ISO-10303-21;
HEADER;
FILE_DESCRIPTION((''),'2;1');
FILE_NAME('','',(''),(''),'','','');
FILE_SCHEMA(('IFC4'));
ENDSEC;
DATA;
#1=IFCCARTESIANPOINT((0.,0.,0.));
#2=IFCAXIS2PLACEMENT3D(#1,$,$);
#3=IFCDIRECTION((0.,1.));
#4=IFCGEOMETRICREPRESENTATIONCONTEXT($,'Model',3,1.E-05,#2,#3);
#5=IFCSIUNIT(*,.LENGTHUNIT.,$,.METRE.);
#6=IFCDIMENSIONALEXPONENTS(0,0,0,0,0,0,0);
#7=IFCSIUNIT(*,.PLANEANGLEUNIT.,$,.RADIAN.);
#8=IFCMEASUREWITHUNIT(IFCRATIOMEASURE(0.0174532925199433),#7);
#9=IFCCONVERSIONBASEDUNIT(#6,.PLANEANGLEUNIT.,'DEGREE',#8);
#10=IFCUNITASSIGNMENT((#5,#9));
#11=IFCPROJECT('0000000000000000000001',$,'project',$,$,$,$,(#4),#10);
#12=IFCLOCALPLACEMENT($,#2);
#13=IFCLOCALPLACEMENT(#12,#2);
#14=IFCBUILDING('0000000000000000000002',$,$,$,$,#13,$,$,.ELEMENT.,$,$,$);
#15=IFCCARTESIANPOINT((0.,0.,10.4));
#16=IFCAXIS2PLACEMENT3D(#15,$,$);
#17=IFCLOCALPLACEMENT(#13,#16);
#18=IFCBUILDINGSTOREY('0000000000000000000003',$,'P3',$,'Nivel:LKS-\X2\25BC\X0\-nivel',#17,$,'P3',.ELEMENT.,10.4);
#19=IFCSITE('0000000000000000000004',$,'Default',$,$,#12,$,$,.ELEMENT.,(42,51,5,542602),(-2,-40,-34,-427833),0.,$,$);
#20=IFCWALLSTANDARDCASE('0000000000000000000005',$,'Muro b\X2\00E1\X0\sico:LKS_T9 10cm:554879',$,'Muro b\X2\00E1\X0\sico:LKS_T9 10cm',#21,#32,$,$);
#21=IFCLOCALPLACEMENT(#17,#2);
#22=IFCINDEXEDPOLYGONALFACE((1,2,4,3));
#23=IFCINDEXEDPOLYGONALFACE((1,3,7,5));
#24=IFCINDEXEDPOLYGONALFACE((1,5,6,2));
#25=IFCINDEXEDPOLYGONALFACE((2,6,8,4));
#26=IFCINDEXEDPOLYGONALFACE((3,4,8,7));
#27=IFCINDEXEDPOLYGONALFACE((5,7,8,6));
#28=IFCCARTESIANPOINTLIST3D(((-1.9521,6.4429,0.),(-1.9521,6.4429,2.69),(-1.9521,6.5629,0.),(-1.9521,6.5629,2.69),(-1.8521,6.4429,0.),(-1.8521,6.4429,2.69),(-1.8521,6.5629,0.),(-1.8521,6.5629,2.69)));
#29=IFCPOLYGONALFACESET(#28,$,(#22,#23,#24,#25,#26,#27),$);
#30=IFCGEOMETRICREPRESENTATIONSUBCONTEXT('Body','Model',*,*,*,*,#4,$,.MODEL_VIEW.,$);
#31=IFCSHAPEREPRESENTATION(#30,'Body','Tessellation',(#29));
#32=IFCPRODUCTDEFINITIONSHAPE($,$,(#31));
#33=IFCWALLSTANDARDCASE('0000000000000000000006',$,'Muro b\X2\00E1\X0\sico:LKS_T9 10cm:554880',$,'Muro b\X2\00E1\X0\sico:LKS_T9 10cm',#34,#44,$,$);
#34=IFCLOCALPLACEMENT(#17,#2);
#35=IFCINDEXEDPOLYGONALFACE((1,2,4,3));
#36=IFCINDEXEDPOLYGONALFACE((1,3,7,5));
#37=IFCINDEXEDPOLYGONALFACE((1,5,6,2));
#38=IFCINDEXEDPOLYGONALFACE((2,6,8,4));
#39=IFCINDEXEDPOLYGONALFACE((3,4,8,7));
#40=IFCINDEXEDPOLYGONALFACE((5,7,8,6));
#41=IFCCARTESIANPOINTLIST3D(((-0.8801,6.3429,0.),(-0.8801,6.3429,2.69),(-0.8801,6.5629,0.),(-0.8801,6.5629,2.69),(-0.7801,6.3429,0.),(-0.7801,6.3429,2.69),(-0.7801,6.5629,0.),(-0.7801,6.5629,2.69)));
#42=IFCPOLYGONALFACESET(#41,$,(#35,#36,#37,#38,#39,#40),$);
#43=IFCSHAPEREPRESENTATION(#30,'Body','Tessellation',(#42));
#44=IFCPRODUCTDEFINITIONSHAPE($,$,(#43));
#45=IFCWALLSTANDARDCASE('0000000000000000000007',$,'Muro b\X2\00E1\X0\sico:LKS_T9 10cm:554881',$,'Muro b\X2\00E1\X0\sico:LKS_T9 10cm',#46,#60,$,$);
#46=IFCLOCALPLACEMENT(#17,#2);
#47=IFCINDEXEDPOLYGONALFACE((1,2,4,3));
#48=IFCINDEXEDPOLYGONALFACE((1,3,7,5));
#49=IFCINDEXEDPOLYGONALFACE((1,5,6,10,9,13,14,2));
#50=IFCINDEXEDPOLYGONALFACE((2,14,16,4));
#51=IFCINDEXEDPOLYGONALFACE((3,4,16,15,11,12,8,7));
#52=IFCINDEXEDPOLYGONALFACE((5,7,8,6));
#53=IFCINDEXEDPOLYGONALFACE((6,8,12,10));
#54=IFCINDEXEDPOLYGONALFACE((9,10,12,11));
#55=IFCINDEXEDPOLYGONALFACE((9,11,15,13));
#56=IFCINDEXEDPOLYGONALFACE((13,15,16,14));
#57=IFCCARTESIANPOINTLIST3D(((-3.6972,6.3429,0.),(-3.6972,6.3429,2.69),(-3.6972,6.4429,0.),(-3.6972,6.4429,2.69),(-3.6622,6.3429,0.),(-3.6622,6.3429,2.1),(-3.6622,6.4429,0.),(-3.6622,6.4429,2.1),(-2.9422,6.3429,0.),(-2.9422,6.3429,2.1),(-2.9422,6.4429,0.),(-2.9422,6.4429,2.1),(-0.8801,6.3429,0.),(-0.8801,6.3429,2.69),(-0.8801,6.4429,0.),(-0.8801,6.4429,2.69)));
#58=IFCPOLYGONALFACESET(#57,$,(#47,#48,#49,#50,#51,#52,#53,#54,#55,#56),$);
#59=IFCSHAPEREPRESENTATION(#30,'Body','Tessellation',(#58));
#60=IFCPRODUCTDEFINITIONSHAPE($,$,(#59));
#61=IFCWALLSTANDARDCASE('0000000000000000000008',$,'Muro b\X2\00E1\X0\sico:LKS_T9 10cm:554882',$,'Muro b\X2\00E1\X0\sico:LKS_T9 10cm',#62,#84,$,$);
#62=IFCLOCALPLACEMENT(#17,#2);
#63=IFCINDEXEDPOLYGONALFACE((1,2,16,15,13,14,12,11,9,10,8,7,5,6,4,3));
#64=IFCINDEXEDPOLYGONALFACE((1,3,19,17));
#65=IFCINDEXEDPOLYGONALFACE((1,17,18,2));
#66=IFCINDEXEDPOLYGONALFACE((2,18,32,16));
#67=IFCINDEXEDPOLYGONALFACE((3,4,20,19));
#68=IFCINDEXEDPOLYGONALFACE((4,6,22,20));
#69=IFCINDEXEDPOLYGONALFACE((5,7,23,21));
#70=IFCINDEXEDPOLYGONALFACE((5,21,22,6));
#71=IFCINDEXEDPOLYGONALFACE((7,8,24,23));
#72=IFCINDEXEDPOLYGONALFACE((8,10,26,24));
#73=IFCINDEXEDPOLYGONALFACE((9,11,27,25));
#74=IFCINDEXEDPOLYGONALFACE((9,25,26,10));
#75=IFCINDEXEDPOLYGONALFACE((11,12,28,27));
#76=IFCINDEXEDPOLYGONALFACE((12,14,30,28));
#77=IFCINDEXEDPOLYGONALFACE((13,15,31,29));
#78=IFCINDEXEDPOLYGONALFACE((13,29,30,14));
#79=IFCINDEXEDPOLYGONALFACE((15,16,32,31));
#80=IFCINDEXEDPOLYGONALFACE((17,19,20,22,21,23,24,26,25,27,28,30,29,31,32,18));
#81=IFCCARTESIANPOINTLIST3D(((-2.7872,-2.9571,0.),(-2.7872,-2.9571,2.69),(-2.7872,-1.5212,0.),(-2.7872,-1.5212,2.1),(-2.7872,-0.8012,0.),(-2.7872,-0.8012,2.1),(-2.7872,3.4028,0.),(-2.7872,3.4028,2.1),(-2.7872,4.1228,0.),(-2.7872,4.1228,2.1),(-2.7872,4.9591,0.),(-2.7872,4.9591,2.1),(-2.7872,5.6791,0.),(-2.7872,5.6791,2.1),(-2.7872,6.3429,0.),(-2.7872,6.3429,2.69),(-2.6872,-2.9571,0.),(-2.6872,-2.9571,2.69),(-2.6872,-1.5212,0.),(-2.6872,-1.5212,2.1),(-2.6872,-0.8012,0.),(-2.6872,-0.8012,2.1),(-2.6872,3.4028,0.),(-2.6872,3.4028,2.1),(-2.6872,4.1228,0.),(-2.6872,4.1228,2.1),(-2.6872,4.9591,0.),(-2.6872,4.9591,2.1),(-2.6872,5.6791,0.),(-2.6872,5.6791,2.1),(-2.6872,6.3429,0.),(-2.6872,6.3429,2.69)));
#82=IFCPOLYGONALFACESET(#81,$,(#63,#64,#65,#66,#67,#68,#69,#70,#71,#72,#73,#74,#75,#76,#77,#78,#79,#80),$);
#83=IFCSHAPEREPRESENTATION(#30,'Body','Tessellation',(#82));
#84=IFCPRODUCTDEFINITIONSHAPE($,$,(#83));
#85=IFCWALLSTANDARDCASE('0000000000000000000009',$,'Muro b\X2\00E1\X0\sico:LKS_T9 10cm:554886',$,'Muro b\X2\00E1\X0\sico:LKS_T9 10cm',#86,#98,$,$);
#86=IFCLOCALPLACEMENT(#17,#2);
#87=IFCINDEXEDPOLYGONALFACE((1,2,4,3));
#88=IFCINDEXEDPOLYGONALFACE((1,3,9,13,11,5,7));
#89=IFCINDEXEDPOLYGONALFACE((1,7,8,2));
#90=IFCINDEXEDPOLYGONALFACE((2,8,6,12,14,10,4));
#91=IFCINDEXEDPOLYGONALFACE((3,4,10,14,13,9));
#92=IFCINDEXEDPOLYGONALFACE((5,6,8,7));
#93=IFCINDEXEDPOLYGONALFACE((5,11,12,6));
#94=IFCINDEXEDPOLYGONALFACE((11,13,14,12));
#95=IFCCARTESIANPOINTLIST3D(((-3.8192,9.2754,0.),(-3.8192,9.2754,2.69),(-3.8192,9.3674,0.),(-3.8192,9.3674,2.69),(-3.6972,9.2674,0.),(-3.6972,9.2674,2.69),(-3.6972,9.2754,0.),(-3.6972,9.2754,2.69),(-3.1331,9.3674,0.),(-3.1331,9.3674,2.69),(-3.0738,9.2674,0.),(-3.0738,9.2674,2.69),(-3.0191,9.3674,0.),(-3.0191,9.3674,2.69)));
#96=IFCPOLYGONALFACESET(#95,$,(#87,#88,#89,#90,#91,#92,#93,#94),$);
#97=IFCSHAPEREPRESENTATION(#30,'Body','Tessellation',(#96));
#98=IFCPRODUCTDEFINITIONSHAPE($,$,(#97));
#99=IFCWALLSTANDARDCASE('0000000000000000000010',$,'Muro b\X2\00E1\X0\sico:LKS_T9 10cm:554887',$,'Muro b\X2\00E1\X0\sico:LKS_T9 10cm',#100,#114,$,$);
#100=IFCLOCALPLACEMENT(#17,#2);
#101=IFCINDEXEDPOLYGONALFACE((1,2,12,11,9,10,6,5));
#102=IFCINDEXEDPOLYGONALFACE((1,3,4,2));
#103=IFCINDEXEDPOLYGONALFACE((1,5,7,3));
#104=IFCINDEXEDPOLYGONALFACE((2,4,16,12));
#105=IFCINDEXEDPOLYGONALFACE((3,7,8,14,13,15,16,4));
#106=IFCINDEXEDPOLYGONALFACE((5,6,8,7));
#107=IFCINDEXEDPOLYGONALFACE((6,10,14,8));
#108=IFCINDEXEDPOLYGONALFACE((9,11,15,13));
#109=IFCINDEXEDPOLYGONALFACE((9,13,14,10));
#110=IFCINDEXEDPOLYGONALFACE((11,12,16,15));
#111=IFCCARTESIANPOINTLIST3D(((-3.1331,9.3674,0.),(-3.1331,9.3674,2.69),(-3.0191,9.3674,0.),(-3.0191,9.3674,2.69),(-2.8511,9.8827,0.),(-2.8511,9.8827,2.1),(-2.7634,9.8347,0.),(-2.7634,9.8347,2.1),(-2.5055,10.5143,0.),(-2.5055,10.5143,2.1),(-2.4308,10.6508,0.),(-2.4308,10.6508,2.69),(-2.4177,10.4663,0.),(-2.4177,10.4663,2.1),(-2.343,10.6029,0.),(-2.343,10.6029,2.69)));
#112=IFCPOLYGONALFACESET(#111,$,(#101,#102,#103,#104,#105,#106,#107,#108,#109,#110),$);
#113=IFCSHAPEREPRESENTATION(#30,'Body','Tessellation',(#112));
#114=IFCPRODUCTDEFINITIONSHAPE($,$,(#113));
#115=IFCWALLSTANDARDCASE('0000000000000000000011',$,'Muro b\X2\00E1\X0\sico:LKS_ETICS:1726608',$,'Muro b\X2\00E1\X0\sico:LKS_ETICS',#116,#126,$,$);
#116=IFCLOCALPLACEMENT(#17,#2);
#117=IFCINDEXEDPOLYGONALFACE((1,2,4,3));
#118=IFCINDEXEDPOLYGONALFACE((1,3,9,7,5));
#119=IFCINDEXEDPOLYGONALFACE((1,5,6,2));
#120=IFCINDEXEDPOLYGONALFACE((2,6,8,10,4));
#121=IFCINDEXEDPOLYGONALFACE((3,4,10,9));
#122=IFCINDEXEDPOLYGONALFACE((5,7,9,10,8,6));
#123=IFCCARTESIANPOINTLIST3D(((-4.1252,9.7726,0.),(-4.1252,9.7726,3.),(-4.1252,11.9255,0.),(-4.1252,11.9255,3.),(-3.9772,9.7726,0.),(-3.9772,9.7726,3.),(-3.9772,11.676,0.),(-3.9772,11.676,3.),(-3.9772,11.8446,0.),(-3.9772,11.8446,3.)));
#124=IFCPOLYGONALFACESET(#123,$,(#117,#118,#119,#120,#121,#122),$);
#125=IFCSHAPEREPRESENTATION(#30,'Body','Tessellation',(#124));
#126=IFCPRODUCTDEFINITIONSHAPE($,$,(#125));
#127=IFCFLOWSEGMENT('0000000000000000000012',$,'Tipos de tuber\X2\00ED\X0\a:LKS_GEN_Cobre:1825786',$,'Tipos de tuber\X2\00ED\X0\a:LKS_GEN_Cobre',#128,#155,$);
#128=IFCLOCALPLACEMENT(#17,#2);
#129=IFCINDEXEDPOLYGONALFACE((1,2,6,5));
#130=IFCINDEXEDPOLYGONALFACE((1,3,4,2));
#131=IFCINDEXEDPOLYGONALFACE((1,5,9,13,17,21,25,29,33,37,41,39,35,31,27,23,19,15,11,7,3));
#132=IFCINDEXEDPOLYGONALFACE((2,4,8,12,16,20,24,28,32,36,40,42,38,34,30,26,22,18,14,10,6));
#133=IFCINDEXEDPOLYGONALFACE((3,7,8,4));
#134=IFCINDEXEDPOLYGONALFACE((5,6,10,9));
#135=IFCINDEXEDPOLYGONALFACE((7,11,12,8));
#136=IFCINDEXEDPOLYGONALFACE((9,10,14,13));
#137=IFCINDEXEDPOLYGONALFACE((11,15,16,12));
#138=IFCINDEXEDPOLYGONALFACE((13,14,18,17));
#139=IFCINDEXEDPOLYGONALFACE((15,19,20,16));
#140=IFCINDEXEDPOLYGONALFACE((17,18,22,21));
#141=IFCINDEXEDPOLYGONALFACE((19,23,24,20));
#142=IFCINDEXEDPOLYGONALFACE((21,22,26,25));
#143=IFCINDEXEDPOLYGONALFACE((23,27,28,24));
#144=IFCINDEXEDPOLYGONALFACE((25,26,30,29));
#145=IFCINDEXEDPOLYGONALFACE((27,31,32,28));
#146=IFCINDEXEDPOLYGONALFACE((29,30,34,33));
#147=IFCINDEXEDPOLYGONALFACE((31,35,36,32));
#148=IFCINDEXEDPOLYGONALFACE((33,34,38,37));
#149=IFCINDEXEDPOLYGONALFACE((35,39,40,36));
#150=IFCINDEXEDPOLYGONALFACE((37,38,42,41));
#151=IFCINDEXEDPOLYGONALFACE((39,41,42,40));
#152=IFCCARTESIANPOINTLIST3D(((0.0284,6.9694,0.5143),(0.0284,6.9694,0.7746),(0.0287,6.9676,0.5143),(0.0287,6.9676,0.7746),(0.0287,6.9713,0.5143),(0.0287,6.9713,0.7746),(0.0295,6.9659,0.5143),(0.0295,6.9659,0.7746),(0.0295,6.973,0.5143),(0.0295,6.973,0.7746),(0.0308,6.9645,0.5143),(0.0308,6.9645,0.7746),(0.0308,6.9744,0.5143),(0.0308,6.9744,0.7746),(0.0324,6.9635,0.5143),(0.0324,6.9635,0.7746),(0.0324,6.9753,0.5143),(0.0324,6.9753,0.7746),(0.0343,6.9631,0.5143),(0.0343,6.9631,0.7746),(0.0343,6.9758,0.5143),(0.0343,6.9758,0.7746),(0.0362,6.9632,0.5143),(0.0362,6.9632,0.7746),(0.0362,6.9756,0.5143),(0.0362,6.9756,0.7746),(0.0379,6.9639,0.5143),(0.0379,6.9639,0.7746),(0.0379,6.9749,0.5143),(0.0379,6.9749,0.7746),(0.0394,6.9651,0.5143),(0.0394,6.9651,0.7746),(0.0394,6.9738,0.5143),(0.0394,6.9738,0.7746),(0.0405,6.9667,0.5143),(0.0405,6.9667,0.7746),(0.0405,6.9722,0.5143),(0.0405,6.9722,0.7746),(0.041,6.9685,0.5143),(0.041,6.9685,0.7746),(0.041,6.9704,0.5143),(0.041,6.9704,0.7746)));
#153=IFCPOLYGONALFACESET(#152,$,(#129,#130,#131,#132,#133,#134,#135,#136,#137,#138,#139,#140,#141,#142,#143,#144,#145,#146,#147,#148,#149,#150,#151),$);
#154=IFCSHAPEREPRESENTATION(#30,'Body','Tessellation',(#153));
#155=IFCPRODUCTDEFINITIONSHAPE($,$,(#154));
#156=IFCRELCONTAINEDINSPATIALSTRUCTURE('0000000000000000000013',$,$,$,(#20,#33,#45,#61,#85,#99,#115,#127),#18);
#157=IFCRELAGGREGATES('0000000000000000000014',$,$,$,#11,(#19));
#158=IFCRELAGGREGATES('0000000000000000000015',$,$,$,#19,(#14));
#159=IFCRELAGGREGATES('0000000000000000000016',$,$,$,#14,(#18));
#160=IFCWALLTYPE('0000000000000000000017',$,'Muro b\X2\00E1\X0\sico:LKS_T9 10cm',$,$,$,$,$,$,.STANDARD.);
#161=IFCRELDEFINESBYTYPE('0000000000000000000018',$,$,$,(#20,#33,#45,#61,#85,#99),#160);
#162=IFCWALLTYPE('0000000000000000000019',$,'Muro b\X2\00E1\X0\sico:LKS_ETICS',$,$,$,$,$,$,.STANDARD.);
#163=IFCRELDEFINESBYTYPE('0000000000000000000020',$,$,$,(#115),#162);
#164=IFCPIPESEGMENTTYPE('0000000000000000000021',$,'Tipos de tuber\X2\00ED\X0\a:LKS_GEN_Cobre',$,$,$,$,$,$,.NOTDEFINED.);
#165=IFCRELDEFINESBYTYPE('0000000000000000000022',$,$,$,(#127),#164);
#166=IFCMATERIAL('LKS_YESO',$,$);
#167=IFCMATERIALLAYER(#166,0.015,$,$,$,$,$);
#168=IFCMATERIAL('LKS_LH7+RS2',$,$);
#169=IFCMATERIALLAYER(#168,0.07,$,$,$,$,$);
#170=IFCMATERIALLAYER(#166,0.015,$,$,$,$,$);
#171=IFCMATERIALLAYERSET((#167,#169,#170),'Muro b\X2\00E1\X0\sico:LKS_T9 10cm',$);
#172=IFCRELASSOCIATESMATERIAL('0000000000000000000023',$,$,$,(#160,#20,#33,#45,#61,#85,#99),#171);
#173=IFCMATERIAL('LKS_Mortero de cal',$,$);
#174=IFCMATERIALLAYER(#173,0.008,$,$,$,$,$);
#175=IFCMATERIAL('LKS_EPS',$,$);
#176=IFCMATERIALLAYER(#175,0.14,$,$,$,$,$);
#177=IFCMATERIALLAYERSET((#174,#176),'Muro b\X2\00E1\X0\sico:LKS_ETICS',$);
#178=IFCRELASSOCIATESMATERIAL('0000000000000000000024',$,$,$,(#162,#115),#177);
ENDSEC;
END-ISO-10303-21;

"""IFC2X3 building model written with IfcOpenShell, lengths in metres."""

from ifc_helpers import new_model, entity, si_unit, converted_unit, direction, frame, frame_2d, origin, place, context, subcontext, project, spatial, polyline, rectangle, circle, outline, extrude, material, layer, layer_set, layer_usage, type_object, element, save


model = new_model("IFC2X3")

# Units and contexts
model_context = context("Model", 3, precision=1e-05, world=origin(), true_north=direction((0.0, 1.0)))
body_context = subcontext(model_context, "Body", "Model", "MODEL_VIEW")
ifc_project = project(units=[si_unit("LENGTHUNIT", "METRE"), converted_unit("PLANEANGLEUNIT", "DEGREE", entity("IfcRatioMeasure", 0.0174532925199433), si_unit("PLANEANGLEUNIT", "RADIAN"), dimensions=[0, 0, 0, 0, 0, 0, 0])], contexts=[model_context])

# Site, building, storey
site_placement = place(None, origin())
site = spatial("IfcSite", under=ifc_project, at=site_placement, Name="Default", CompositionType="ELEMENT", RefLatitude=(42, 51, 5, 542602), RefLongitude=(-2, -40, -34, -427833), RefElevation=0.0)
building_placement = place(site_placement, origin())
building = spatial("IfcBuilding", under=site, at=building_placement, CompositionType="ELEMENT")
storey_placement = place(building_placement, frame((0.0, 0.0, 10.4)))
storey = spatial("IfcBuildingStorey", under=building, at=storey_placement, Name="P3", ObjectType="Nivel:LKS-▼-nivel", LongName="P3", CompositionType="ELEMENT", Elevation=10.4)

# Walls
ifc_material_1 = material(Name="LKS_YESO")
ifc_layer_1 = layer(ifc_material_1, 0.015)
ifc_material_2 = material(Name="LKS_LH7+RS2")
ifc_layer_2 = layer(ifc_material_2, 0.07)
ifc_layer_3 = layer(ifc_material_1, 0.015)
ifc_layer_set_1 = layer_set([ifc_layer_1, ifc_layer_2, ifc_layer_3], Name="Muro básico:LKS_T9 10cm")
ifc_layer_usage_1 = layer_usage(ifc_layer_set_1, "AXIS2", "NEGATIVE", 0.05)
wall_type_1 = type_object("IfcWallType", Name="Muro básico:LKS_T9 10cm", PredefinedType="STANDARD", material=ifc_layer_set_1)
wall_1_placement = place(storey_placement, frame((-1.9021, 6.5629, 0.0), z_axis=(0.0, 0.0, 1.0), x_axis=(0.0, -1.0, 0.0)))
element("IfcWallStandardCase", 1, at=wall_1_placement, inside=storey, type_object=wall_type_1, material=ifc_layer_usage_1, Name="Muro básico:LKS_T9 10cm:554879", ObjectType="Muro básico:LKS_T9 10cm", context=body_context, shape_type="SweptSolid", body=[
    extrude(rectangle(XDim=0.12, YDim=0.1, at=frame_2d((0.06, 0.0), x_axis=(-1.0, 0.0))), origin(), (0.0, 0.0, 1.0), 2.69),
])
ifc_layer_usage_2 = layer_usage(ifc_layer_set_1, "AXIS2", "NEGATIVE", 0.05)
wall_2_placement = place(storey_placement, frame((-0.8301, 6.5629, 0.0), z_axis=(0.0, 0.0, 1.0), x_axis=(0.0, -1.0, 0.0)))
element("IfcWallStandardCase", 2, at=wall_2_placement, inside=storey, type_object=wall_type_1, material=ifc_layer_usage_2, Name="Muro básico:LKS_T9 10cm:554880", ObjectType="Muro básico:LKS_T9 10cm", context=body_context, shape_type="SweptSolid", body=[
    extrude(rectangle(XDim=0.22, YDim=0.1, at=frame_2d((0.11, 0.0), x_axis=(-1.0, 0.0))), origin(), (0.0, 0.0, 1.0), 2.69),
])

# Wall, opening
ifc_layer_usage_3 = layer_usage(ifc_layer_set_1, "AXIS2", "NEGATIVE", 0.05)
wall_3_placement = place(storey_placement, frame((-0.8801, 6.3929, 0.0), z_axis=(0.0, 0.0, 1.0), x_axis=(-1.0, 0.0, 0.0)))
wall_3 = element("IfcWallStandardCase", 3, at=wall_3_placement, inside=storey, type_object=wall_type_1, material=ifc_layer_usage_3, Name="Muro básico:LKS_T9 10cm:554881", ObjectType="Muro básico:LKS_T9 10cm", context=body_context, shape_type="SweptSolid", body=[
    extrude(rectangle(XDim=2.8171, YDim=0.1, at=frame_2d((1.4085, 0.0), x_axis=(-1.0, 0.0))), origin(), (0.0, 0.0, 1.0), 2.69),
])
opening_1_placement = place(wall_3_placement, frame((2.7821, 0.05, 0.0)))
element("IfcOpeningElement", 4, at=opening_1_placement, cuts=wall_3, ObjectType="Opening", context=body_context, shape_type="SweptSolid", body=[
    extrude(rectangle(XDim=2.1, YDim=0.72, at=frame_2d((1.05, 0.36), x_axis=(1.0, 0.0))), frame((0.0, 0.0, 0.0), z_axis=(0.0, -1.0, 0.0), x_axis=(0.0, 0.0, 1.0)), (0.0, 0.0, 1.0), 0.1),
])

# Wall, openings
ifc_layer_usage_4 = layer_usage(ifc_layer_set_1, "AXIS2", "NEGATIVE", 0.05)
wall_4_placement = place(storey_placement, frame((-2.7372, 6.3429, 0.0), z_axis=(0.0, 0.0, 1.0), x_axis=(0.0, -1.0, 0.0)))
wall_4 = element("IfcWallStandardCase", 5, at=wall_4_placement, inside=storey, type_object=wall_type_1, material=ifc_layer_usage_4, Name="Muro básico:LKS_T9 10cm:554882", ObjectType="Muro básico:LKS_T9 10cm", context=body_context, shape_type="SweptSolid", body=[
    extrude(rectangle(XDim=9.3, YDim=0.1, at=frame_2d((4.65, 0.0), x_axis=(-1.0, 0.0))), origin(), (0.0, 0.0, 1.0), 2.69),
])
opening_2_placement = place(wall_4_placement, frame((0.6638, -0.05, 0.0)))
element("IfcOpeningElement", 6, at=opening_2_placement, cuts=wall_4, ObjectType="Opening", context=body_context, shape_type="SweptSolid", body=[
    extrude(rectangle(XDim=2.1, YDim=0.72, at=frame_2d((1.05, 0.36), x_axis=(1.0, 0.0))), frame((0.0, 0.0, 0.0), z_axis=(0.0, 1.0, 0.0), x_axis=(0.0, 0.0, 1.0)), (0.0, 0.0, 1.0), 0.1),
])
opening_3_placement = place(wall_4_placement, frame((2.22, -0.05, 0.0)))
element("IfcOpeningElement", 7, at=opening_3_placement, cuts=wall_4, ObjectType="Opening", context=body_context, shape_type="SweptSolid", body=[
    extrude(rectangle(XDim=2.1, YDim=0.72, at=frame_2d((1.05, 0.36), x_axis=(1.0, 0.0))), frame((0.0, 0.0, 0.0), z_axis=(0.0, 1.0, 0.0), x_axis=(0.0, 0.0, 1.0)), (0.0, 0.0, 1.0), 0.1),
])
opening_4_placement = place(wall_4_placement, frame((7.1441, -0.05, 0.0)))
element("IfcOpeningElement", 8, at=opening_4_placement, cuts=wall_4, ObjectType="Opening", context=body_context, shape_type="SweptSolid", body=[
    extrude(rectangle(XDim=2.1, YDim=0.72, at=frame_2d((1.05, 0.36), x_axis=(1.0, 0.0))), frame((0.0, 0.0, 0.0), z_axis=(0.0, 1.0, 0.0), x_axis=(0.0, 0.0, 1.0)), (0.0, 0.0, 1.0), 0.1),
])

# Wall
ifc_layer_usage_5 = layer_usage(ifc_layer_set_1, "AXIS2", "NEGATIVE", 0.05)
wall_5_placement = place(storey_placement, frame((-3.8192, 9.3174, 0.0)))
element("IfcWallStandardCase", 9, at=wall_5_placement, inside=storey, type_object=wall_type_1, material=ifc_layer_usage_5, Name="Muro básico:LKS_T9 10cm:554886", ObjectType="Muro básico:LKS_T9 10cm", context=body_context, shape_type="SweptSolid", body=[
    extrude(outline(polyline([(0.7454, -0.05), (0.8001, 0.05), (0.6861, 0.05), (0.0, 0.05), (0.0, -0.042), (0.122, -0.042), (0.122, -0.05), (0.7454, -0.05)])), origin(), (0.0, 0.0, 1.0), 2.69),
])

# Wall, opening
ifc_layer_usage_6 = layer_usage(ifc_layer_set_1, "AXIS2", "NEGATIVE", 0.05)
wall_6_placement = place(storey_placement, frame((-3.0892, 9.3434, 0.0), z_axis=(0.0, 0.0, 1.0), x_axis=(0.480022, 0.877256, 0.0)))
wall_6 = element("IfcWallStandardCase", 10, at=wall_6_placement, inside=storey, type_object=wall_type_1, material=ifc_layer_usage_6, Name="Muro básico:LKS_T9 10cm:554887", ObjectType="Muro básico:LKS_T9 10cm", context=body_context, shape_type="SweptSolid", body=[
    extrude(outline(polyline([(0.0547, -0.05), (1.4631, -0.05), (1.463, 0.05), (0.0, 0.05), (0.0547, -0.05)])), origin(), (0.0, 0.0, 1.0), 2.69),
])
opening_5_placement = place(wall_6_placement, frame((1.3075, 0.05, 0.0)))
element("IfcOpeningElement", 11, at=opening_5_placement, cuts=wall_6, ObjectType="Opening", context=body_context, shape_type="SweptSolid", body=[
    extrude(rectangle(XDim=2.1, YDim=0.72, at=frame_2d((1.05, 0.36), x_axis=(1.0, 0.0))), frame((0.0, 0.0, 0.0), z_axis=(0.0, -1.0, 0.0), x_axis=(0.0, 0.0, 1.0)), (0.0, 0.0, 1.0), 0.1),
])

# Wall
ifc_material_3 = material(Name="LKS_Mortero de cal")
ifc_layer_4 = layer(ifc_material_3, 0.008)
ifc_material_4 = material(Name="LKS_EPS")
ifc_layer_5 = layer(ifc_material_4, 0.14)
ifc_layer_set_2 = layer_set([ifc_layer_4, ifc_layer_5], Name="Muro básico:LKS_ETICS")
ifc_layer_usage_7 = layer_usage(ifc_layer_set_2, "AXIS2", "NEGATIVE", 0.074)
wall_type_2 = type_object("IfcWallType", Name="Muro básico:LKS_ETICS", PredefinedType="STANDARD", material=ifc_layer_set_2)
wall_7_placement = place(storey_placement, frame((-4.0512, 9.7726, 0.0), z_axis=(0.0, 0.0, 1.0), x_axis=(0.0, 1.0, 0.0)))
element("IfcWallStandardCase", 12, at=wall_7_placement, inside=storey, type_object=wall_type_2, material=ifc_layer_usage_7, Name="Muro básico:LKS_ETICS:1726608", ObjectType="Muro básico:LKS_ETICS", context=body_context, shape_type="SweptSolid", body=[
    extrude(outline(polyline([(2.072, -0.074), (2.1529, 0.074), (0.0, 0.074), (0.0, -0.074), (1.9033, -0.074), (2.072, -0.074)])), origin(), (0.0, 0.0, 1.0), 3.0),
])

# Flow segment
pipe_segment_type_1 = type_object("IfcPipeSegmentType", Name="Tipos de tubería:LKS_GEN_Cobre", PredefinedType="NOTDEFINED")
flow_segment_1_placement = place(storey_placement, origin())
element("IfcFlowSegment", 13, at=flow_segment_1_placement, inside=storey, type_object=pipe_segment_type_1, Name="Tipos de tubería:LKS_GEN_Cobre:1825786", ObjectType="Tipos de tubería:LKS_GEN_Cobre", context=body_context, shape_type="SweptSolid", body=[
    extrude(circle(Radius=0.0063, at=frame_2d((0.0, 0.0), x_axis=(1.0, 0.0))), frame((0.0348, 6.9694, 0.5143), z_axis=(0.0, 0.0, 1.0), x_axis=(-1.0, 0.0, 0.0)), (0.0, 0.0, 1.0), 0.2603),
])

save(model, "model.ifc")
